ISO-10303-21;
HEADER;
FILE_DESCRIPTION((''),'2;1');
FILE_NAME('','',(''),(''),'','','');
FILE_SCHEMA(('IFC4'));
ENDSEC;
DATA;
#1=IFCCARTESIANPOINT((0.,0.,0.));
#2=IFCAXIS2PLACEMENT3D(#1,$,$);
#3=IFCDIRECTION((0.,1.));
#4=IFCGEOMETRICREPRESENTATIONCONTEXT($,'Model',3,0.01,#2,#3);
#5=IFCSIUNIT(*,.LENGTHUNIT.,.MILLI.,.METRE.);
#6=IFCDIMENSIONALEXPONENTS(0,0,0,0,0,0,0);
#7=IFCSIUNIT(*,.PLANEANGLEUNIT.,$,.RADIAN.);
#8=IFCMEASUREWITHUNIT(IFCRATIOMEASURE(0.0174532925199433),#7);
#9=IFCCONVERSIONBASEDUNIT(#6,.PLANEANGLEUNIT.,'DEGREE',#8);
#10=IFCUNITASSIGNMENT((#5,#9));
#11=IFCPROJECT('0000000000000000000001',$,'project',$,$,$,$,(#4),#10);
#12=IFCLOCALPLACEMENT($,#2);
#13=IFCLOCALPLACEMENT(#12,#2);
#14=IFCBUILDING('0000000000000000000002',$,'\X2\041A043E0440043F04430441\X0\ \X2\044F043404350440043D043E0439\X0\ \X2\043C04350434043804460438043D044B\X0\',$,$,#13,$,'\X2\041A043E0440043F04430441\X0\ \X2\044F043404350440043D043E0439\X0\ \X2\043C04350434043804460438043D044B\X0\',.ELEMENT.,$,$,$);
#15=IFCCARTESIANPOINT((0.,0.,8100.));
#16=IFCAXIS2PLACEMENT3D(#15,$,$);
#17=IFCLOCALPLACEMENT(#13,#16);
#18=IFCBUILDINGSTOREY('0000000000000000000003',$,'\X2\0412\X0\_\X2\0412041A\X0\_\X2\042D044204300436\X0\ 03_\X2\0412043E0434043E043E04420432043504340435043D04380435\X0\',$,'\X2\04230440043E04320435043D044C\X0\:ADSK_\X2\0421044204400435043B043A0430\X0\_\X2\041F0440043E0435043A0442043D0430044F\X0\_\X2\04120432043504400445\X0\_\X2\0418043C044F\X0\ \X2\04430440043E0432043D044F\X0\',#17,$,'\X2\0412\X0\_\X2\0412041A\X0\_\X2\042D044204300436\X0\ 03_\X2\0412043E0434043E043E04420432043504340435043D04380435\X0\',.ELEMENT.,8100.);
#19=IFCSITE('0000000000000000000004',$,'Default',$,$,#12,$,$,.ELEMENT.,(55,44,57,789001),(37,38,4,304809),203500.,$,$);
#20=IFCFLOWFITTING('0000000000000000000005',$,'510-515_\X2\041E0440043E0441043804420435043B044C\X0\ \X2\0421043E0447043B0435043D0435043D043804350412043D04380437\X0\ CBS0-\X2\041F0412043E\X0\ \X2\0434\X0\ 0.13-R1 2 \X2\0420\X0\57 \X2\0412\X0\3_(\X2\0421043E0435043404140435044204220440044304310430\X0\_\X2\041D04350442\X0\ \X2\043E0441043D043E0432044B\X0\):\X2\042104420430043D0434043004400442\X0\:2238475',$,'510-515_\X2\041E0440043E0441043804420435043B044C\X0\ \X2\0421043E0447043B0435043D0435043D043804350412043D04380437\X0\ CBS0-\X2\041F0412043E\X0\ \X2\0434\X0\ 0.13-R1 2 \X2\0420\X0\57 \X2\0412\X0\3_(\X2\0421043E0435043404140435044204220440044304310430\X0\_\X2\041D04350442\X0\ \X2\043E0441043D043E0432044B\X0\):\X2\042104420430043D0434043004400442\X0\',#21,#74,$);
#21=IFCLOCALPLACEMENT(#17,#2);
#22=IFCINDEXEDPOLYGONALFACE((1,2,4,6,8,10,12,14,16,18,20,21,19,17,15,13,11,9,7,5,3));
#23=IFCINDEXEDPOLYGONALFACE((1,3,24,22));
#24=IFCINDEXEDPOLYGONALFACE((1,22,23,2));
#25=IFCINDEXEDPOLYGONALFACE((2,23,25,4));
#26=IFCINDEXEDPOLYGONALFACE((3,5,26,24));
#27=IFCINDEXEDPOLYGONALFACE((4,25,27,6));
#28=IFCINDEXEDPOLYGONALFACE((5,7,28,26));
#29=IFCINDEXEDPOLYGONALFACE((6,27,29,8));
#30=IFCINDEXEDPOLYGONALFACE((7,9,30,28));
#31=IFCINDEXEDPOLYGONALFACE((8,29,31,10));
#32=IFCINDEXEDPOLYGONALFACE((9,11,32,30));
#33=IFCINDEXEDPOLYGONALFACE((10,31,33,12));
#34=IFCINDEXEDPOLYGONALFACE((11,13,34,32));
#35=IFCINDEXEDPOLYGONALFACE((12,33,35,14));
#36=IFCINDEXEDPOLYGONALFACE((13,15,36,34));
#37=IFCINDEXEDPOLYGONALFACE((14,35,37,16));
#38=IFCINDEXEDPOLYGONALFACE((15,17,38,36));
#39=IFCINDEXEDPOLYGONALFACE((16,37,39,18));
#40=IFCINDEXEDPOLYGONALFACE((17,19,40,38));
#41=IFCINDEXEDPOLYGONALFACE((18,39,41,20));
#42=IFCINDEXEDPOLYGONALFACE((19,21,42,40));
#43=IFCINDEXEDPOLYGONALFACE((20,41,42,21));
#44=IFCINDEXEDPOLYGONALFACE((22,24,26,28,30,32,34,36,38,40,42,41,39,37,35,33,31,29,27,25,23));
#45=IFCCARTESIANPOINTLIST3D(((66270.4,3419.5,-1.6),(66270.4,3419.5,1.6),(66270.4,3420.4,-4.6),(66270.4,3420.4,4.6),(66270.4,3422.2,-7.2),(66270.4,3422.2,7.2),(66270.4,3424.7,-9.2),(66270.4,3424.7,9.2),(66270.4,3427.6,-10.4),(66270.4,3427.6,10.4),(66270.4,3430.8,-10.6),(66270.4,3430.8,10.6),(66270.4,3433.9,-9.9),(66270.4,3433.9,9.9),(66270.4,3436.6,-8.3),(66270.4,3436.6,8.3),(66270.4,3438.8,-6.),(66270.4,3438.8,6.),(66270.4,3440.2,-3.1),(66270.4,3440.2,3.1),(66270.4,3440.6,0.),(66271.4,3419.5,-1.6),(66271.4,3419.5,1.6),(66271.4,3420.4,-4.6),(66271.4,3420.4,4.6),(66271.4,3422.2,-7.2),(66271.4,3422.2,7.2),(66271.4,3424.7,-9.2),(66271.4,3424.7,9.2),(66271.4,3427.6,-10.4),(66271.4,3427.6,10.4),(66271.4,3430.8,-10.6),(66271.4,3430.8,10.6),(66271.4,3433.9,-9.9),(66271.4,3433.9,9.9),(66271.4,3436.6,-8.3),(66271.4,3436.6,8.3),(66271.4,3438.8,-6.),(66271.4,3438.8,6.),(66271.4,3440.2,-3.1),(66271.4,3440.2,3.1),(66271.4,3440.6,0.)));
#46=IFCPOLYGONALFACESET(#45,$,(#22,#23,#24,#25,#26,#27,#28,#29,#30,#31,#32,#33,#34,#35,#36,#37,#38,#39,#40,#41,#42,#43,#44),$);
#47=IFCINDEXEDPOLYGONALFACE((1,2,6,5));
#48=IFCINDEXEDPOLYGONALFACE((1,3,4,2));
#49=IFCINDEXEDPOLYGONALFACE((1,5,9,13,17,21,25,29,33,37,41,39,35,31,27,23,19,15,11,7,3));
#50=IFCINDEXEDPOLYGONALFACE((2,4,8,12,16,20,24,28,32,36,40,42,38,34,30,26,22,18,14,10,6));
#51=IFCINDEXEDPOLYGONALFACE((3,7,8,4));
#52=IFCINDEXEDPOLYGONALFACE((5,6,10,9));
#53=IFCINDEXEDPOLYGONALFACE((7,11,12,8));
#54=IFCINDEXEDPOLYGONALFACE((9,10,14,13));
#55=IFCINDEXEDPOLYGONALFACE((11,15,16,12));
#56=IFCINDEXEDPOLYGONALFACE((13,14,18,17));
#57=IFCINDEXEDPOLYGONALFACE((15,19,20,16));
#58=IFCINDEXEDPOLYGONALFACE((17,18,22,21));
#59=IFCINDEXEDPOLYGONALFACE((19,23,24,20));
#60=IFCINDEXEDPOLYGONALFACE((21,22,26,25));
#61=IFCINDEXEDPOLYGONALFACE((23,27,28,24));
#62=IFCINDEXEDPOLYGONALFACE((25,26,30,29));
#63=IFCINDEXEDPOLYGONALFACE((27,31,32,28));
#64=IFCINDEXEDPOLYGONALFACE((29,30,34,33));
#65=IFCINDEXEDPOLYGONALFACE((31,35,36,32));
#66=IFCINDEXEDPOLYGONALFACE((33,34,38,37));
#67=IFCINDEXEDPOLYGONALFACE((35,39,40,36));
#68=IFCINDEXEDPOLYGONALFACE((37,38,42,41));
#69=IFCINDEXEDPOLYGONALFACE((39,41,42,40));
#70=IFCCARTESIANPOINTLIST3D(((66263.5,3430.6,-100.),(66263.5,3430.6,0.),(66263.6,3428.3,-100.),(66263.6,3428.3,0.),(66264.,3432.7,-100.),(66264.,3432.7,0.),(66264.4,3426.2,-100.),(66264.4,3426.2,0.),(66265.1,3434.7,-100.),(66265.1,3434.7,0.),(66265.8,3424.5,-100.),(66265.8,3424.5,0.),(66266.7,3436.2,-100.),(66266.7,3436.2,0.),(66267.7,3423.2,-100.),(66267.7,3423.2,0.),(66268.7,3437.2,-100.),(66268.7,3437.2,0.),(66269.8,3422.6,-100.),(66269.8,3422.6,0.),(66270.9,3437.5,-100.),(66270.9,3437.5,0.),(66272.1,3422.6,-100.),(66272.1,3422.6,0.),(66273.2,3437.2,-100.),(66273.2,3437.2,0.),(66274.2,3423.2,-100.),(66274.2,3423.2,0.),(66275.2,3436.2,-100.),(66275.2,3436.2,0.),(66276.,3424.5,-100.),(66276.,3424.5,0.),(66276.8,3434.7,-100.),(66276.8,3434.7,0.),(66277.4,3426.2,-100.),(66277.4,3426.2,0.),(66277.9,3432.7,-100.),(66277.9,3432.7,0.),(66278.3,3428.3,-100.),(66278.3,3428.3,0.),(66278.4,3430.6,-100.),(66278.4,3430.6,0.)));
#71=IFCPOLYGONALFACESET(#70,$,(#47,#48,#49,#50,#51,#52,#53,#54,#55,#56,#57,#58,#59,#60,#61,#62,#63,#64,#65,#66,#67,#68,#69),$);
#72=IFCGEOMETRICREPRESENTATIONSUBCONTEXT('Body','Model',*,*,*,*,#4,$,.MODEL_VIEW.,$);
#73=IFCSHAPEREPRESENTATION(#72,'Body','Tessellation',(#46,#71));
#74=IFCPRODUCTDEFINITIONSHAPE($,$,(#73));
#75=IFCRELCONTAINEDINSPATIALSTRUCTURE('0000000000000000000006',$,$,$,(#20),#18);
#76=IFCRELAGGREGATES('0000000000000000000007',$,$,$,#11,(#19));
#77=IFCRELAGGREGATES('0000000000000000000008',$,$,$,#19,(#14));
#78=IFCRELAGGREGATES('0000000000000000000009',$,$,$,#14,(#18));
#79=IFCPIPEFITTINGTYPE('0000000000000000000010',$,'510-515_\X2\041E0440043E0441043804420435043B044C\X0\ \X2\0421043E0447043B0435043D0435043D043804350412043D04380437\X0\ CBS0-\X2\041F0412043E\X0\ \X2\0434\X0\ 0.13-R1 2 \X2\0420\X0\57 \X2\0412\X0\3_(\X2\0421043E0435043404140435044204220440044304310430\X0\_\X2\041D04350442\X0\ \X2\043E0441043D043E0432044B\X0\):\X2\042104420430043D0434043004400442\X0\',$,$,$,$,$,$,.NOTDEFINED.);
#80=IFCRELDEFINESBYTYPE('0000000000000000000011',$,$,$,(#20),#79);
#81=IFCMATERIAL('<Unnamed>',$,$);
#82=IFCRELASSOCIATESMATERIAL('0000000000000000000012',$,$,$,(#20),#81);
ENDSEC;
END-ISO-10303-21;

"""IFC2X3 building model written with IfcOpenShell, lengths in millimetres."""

from ifc_helpers import new_model, entity, si_unit, converted_unit, direction, frame, origin, origin_2d_with_axis, place, context, subcontext, project, spatial, circle, extrude, source, transform, mapped, material, type_object, type_shapes, element, save


model = new_model("IFC2X3")

# Units and contexts
model_context = context("Model", 3, precision=0.01, world=origin(), true_north=direction((0.0, 1.0)))
body_context = subcontext(model_context, "Body", "Model", "MODEL_VIEW")
ifc_project = project(units=[si_unit("LENGTHUNIT", "METRE", prefix="MILLI"), converted_unit("PLANEANGLEUNIT", "DEGREE", entity("IfcRatioMeasure", 0.0174532925199433), si_unit("PLANEANGLEUNIT", "RADIAN"), dimensions=[0, 0, 0, 0, 0, 0, 0])], contexts=[model_context])

# Site, building, storey
site_placement = place(None, origin())
site = spatial("IfcSite", under=ifc_project, at=site_placement, Name="Default", CompositionType="ELEMENT", RefLatitude=(55, 44, 57, 789001), RefLongitude=(37, 38, 4, 304809), RefElevation=203500.0)
building_placement = place(site_placement, origin())
building = spatial("IfcBuilding", under=site, at=building_placement, Name="Корпус ядерной медицины", LongName="Корпус ядерной медицины", CompositionType="ELEMENT")
storey_placement = place(building_placement, frame((0.0, 0.0, 8100.0)))
storey = spatial("IfcBuildingStorey", under=building, at=storey_placement, Name="В_ВК_Этаж 03_Водоотведение", ObjectType="Уровень:ADSK_Стрелка_Проектная_Вверх_Имя уровня", LongName="В_ВК_Этаж 03_Водоотведение", CompositionType="ELEMENT", Elevation=8100.0)

# Flow fitting
ifc_material_1 = material(Name="<Unnamed>")
pipe_fitting_type = type_object("IfcPipeFittingType", Name="510-515_Ороситель СочленениеВниз CBS0-ПВо д 0.13-R1 2 Р57 В3_(СоедДетТруба_Нет основы):Стандарт", PredefinedType="NOTDEFINED")
shared_shape_1 = source(origin(), body_context, "Body", "SweptSolid", [
    extrude(circle(Radius=10.7, at=origin_2d_with_axis()), frame((-0.5, 0.0, 0.0), z_axis=(1.0, 0.0, 0.0), x_axis=(0.0, 1.0, 0.0)), (0.0, 0.0, 1.0), 1.0),
    extrude(circle(Radius=7.5, at=origin_2d_with_axis()), frame((0.0, 0.0, -100.0), z_axis=(0.0, 0.0, 1.0), x_axis=(0.0, 1.0, 0.0)), (0.0, 0.0, 1.0), 100.0),
])
type_shapes(pipe_fitting_type, [shared_shape_1])
for number, where, name in (
    (1, (66270.9, 3430.0, 0.0), "510-515_Ороситель СочленениеВниз CBS0-ПВо д 0.13-R1 2 Р57 В3_(СоедДетТруба_Нет основы):Стандарт:2238475"),
):
    element("IfcFlowFitting", number, at=place(storey_placement, frame(where)), inside=storey, type_object=pipe_fitting_type, material=ifc_material_1, Name=name, ObjectType="510-515_Ороситель СочленениеВниз CBS0-ПВо д 0.13-R1 2 Р57 В3_(СоедДетТруба_Нет основы):Стандарт", context=body_context, shape_type="MappedRepresentation", body=[
        mapped(shared_shape_1, transform((0.0, 0.0, 0.0), scale=1.0)),
    ])

save(model, "model.ifc")
